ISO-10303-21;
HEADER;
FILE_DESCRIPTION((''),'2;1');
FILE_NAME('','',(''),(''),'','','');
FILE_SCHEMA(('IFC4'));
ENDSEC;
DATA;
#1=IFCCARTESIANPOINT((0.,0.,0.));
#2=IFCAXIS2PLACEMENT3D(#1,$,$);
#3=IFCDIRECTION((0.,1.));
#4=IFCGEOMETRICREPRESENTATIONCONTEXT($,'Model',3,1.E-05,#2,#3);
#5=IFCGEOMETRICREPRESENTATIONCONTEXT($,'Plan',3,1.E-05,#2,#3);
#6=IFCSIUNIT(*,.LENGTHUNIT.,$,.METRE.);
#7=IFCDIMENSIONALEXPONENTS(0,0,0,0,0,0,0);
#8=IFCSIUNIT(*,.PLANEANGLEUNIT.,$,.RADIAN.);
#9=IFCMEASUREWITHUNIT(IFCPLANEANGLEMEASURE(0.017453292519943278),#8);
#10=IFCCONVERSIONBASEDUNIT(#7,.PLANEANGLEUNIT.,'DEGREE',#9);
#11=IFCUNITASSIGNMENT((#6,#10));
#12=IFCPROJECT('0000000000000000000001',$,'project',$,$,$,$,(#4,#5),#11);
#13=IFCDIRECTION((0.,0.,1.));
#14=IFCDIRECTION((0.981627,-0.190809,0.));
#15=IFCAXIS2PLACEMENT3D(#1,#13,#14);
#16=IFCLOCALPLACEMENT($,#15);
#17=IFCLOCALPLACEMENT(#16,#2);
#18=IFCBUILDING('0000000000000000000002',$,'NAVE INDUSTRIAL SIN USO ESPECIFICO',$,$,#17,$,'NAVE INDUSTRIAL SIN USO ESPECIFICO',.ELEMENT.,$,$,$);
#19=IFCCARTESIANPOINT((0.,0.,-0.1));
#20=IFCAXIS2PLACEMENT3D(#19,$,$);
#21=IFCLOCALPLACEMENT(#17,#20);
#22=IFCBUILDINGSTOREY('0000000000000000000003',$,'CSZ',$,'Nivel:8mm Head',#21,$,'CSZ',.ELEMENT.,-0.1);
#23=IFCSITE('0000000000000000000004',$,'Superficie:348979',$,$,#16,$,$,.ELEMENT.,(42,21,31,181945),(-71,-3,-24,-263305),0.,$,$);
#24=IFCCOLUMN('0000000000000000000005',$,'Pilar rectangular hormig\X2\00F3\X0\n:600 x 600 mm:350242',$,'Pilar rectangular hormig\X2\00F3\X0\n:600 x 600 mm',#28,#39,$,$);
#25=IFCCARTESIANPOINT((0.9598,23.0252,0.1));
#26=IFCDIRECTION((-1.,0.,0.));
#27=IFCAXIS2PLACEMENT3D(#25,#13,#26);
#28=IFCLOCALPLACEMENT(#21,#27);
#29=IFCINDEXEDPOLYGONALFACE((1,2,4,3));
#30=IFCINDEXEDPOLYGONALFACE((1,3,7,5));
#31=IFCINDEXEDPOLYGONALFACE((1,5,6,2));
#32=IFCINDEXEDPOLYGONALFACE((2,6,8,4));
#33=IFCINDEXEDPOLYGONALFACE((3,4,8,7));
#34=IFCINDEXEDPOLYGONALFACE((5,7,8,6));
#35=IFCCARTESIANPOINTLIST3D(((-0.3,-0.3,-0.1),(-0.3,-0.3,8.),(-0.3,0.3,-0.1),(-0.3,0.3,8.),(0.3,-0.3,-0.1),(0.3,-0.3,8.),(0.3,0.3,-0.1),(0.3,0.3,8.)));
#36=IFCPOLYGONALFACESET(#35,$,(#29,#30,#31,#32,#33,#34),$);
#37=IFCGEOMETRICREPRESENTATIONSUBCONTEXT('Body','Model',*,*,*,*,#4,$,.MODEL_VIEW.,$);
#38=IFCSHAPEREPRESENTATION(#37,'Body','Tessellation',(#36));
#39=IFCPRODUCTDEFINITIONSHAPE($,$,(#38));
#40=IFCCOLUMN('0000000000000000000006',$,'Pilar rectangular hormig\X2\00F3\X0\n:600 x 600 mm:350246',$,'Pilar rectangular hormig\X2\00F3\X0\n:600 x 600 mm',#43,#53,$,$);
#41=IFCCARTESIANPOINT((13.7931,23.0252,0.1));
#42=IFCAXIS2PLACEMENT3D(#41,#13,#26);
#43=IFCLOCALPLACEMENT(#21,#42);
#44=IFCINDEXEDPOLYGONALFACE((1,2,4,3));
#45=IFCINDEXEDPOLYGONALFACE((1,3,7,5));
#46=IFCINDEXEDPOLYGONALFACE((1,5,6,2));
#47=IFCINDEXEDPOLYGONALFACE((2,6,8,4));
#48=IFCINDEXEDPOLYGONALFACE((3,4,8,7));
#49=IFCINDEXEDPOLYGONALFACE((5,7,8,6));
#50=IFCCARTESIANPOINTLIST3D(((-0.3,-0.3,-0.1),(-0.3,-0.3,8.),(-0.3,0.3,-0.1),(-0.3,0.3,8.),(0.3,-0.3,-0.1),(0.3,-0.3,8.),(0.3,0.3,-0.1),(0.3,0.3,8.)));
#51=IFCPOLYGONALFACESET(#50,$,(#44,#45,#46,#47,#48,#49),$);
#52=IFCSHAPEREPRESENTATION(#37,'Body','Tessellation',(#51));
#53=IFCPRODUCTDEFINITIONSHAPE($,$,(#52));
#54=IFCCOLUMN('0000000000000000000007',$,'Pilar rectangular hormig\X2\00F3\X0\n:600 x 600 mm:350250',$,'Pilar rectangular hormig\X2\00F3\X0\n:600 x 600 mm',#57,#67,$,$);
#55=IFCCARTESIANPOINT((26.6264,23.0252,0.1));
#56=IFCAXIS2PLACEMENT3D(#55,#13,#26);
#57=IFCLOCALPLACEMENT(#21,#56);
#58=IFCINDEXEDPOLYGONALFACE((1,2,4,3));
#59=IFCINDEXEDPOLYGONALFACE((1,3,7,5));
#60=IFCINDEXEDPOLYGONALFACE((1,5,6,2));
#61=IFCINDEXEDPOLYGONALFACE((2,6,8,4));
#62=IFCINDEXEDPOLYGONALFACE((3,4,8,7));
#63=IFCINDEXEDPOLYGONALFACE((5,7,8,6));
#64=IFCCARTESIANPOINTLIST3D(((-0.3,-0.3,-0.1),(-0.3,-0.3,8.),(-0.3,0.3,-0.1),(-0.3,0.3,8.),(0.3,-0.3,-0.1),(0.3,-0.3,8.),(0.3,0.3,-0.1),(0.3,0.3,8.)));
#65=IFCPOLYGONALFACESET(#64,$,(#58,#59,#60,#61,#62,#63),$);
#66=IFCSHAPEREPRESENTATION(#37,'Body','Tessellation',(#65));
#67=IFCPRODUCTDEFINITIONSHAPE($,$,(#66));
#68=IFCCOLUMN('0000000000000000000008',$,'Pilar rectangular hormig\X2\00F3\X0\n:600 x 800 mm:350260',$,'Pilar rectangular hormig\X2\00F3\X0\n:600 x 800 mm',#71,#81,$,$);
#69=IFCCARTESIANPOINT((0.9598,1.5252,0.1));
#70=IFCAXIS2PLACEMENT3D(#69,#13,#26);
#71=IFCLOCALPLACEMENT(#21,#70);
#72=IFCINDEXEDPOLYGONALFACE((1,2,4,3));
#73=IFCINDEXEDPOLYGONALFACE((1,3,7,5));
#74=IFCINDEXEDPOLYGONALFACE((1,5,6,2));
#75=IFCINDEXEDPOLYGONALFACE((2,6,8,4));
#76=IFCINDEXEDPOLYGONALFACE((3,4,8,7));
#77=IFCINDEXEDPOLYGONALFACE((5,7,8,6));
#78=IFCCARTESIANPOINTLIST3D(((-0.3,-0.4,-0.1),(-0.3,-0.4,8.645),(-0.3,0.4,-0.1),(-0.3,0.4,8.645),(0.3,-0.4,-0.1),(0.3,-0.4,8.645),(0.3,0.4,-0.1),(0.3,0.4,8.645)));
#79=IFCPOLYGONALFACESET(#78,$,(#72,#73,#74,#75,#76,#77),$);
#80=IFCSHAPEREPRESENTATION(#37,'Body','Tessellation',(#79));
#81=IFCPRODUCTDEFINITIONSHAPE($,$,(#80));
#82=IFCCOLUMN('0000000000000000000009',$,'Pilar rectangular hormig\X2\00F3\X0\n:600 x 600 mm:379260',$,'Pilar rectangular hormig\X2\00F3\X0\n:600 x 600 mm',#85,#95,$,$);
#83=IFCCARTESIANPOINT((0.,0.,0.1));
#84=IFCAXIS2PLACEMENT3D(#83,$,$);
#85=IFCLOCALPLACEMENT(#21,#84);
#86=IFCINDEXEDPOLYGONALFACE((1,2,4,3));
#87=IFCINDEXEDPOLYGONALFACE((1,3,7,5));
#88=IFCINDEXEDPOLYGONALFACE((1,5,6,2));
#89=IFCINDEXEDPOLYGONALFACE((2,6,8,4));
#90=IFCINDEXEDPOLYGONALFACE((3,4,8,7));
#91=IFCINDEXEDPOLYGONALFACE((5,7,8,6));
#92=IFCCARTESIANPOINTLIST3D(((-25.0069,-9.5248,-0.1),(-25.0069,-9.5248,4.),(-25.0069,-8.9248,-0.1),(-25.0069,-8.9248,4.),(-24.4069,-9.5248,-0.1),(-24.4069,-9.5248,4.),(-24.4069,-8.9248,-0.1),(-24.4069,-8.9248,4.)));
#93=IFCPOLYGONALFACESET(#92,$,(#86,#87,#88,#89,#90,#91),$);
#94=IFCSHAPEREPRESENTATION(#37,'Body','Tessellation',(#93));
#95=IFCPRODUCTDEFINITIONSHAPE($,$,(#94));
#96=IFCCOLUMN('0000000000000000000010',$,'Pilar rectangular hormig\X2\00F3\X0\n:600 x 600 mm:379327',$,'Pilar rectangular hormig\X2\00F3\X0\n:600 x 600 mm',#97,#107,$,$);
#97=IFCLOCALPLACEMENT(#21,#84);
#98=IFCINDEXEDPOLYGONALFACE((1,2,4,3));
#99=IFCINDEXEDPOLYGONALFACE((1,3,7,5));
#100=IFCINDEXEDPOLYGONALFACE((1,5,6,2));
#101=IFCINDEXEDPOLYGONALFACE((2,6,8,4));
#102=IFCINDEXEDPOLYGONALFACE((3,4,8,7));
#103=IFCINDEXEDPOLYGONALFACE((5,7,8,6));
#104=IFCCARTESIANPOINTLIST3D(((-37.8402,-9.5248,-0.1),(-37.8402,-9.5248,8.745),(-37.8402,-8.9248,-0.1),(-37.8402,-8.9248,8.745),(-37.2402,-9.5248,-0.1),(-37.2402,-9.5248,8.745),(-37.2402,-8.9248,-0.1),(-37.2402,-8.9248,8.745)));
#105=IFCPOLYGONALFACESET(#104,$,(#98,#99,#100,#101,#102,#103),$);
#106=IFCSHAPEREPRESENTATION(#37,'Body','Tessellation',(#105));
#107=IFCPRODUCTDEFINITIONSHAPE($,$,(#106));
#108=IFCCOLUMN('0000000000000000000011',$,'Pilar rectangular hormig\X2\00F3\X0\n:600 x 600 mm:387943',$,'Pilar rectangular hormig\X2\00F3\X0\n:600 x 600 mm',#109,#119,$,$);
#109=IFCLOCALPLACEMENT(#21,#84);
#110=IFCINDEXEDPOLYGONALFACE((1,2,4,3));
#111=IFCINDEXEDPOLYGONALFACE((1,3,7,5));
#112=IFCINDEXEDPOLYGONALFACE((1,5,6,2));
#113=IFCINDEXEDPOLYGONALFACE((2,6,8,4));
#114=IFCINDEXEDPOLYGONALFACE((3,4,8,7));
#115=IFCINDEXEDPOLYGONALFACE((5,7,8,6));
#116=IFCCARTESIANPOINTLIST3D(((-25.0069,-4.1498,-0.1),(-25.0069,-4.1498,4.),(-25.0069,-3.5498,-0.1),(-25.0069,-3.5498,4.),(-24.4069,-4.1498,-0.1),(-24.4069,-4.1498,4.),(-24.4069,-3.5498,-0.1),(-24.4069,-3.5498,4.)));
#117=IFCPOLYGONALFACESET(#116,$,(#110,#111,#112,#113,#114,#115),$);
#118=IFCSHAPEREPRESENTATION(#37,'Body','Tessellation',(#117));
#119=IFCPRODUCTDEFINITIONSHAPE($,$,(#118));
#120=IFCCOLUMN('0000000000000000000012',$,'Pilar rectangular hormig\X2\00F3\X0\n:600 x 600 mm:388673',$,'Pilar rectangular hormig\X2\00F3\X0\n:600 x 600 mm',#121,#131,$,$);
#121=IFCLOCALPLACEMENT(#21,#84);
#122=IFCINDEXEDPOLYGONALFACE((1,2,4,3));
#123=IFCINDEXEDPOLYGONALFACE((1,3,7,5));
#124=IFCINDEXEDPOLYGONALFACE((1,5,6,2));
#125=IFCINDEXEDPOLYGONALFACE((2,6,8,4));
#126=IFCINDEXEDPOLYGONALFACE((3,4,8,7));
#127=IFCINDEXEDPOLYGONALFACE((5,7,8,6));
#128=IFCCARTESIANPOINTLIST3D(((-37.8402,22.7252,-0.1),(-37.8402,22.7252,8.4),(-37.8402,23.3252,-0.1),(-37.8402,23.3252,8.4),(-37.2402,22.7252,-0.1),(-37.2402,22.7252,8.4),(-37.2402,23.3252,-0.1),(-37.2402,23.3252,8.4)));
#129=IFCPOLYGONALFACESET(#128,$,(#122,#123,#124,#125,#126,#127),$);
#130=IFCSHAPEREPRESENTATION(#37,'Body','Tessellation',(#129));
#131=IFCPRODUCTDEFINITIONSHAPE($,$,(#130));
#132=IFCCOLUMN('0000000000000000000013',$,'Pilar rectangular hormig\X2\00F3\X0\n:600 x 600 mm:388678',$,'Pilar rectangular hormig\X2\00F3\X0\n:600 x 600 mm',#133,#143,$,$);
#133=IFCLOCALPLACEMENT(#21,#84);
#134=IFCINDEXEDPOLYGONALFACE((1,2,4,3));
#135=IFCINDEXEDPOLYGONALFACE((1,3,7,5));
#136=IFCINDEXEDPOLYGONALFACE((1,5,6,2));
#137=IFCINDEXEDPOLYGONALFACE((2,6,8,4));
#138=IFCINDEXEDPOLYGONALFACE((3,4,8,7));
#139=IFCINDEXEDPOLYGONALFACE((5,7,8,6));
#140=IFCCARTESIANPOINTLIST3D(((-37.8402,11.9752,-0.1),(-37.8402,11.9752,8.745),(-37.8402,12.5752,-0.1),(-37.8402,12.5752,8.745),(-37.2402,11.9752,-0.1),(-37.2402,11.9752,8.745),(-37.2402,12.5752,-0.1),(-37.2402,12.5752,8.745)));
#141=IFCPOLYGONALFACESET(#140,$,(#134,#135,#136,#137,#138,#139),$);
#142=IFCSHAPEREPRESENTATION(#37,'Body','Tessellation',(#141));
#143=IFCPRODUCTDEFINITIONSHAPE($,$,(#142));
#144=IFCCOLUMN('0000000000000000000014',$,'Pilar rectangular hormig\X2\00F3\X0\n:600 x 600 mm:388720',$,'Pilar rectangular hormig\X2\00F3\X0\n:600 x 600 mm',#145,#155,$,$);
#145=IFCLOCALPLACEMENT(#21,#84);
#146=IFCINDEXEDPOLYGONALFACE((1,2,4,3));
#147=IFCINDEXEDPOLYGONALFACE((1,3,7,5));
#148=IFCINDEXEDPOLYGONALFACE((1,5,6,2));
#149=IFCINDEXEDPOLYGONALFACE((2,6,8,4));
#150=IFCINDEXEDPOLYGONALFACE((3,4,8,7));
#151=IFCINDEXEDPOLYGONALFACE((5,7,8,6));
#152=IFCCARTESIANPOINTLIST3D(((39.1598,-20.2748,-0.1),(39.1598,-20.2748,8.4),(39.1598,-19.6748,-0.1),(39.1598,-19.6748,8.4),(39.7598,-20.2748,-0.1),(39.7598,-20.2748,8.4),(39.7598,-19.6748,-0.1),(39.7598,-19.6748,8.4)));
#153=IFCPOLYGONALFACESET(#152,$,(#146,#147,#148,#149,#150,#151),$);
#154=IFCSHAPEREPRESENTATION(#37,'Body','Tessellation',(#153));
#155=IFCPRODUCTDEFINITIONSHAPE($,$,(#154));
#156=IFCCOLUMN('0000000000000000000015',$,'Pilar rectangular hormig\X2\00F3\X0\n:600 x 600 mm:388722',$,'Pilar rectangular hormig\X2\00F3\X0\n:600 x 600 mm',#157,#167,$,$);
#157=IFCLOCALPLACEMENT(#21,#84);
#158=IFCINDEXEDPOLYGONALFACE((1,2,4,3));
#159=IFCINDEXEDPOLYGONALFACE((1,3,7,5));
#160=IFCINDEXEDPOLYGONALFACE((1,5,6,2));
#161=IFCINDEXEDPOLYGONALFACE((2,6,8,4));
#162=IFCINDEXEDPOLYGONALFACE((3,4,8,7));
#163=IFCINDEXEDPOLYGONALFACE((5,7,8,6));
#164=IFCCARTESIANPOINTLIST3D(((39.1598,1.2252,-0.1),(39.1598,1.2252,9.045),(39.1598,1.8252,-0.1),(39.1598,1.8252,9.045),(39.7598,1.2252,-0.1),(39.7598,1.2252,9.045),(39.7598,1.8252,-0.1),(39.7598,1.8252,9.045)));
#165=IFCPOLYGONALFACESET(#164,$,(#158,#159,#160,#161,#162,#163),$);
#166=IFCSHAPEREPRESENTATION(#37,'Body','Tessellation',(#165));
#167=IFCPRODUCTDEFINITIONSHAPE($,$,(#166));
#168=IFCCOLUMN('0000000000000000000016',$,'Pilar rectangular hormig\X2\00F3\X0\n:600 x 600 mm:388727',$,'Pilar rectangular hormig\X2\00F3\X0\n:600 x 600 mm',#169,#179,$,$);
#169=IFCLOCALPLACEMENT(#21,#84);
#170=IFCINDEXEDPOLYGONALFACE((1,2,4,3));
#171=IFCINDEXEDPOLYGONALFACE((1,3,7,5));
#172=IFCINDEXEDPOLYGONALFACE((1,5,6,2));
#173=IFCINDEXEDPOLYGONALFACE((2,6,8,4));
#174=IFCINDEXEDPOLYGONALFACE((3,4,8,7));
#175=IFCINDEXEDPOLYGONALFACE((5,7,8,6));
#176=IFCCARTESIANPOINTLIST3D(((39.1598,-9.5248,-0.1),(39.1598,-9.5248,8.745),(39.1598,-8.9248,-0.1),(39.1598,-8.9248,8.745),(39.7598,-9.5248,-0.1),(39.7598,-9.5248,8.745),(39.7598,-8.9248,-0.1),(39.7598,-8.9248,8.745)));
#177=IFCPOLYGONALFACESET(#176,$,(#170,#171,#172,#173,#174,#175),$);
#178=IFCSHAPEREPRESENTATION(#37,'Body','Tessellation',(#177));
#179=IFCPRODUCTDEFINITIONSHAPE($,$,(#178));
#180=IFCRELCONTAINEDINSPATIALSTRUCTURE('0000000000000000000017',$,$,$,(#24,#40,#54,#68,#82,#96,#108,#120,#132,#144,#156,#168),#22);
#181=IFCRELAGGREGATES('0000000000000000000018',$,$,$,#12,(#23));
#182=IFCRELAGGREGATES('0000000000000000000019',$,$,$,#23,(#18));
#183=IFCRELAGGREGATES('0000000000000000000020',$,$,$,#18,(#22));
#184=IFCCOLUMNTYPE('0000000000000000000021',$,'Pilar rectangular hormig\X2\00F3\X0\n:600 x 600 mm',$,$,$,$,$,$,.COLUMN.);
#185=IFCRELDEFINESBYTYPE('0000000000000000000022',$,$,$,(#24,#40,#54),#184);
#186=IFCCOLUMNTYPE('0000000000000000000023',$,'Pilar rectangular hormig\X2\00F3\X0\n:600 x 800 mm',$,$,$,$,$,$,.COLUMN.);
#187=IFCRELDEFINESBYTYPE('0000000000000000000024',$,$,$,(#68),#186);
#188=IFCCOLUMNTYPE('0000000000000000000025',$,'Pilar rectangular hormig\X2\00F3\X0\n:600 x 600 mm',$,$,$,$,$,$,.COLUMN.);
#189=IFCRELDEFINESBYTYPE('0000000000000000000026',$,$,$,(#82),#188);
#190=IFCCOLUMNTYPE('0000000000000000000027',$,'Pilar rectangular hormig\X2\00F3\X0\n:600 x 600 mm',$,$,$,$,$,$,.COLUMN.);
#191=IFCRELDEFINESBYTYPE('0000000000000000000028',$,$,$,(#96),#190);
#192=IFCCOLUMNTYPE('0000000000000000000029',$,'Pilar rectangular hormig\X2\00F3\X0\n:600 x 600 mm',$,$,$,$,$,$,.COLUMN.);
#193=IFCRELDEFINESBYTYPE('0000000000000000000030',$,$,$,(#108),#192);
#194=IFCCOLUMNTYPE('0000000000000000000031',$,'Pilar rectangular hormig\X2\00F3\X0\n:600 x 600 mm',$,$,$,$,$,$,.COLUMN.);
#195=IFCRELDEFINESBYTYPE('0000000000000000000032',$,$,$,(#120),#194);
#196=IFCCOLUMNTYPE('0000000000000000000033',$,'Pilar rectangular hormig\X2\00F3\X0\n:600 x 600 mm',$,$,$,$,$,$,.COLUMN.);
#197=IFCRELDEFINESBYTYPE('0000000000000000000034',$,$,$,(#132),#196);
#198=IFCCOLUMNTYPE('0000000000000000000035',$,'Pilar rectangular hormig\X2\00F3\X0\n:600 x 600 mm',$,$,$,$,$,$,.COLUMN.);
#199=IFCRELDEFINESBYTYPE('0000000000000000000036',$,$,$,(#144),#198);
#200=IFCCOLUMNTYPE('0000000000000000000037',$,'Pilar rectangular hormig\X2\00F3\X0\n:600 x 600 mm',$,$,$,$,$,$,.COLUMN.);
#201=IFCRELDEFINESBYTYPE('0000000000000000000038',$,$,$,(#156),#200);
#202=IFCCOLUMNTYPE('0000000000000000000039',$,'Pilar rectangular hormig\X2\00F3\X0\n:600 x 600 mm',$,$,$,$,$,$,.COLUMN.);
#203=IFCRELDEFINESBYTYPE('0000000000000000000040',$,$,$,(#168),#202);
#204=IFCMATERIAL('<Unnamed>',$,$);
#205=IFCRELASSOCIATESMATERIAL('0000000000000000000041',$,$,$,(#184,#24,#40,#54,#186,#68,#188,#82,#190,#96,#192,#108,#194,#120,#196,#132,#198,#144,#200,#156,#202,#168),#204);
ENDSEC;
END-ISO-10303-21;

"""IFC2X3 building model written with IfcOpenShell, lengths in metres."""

from ifc_helpers import new_model, entity, si_unit, converted_unit, direction, frame, frame_2d, origin, origin_2d_with_axis, place, context, subcontext, project, spatial, rectangle, extrude, source, transform, mapped, material, type_object, type_shapes, element, save


model = new_model("IFC2X3")

# Units and contexts
model_context = context("Model", 3, precision=1e-05, world=origin(), true_north=direction((0.0, 1.0)))
plan_context = context("Plan", 3, precision=1e-05, world=origin(), true_north=direction((0.0, 1.0)))
body_context = subcontext(model_context, "Body", "Model", "MODEL_VIEW")
ifc_project = project(units=[si_unit("LENGTHUNIT", "METRE"), converted_unit("PLANEANGLEUNIT", "DEGREE", entity("IfcPlaneAngleMeasure", 0.017453292519943278), si_unit("PLANEANGLEUNIT", "RADIAN"), dimensions=[0, 0, 0, 0, 0, 0, 0])], contexts=[model_context, plan_context])

# Site, building, storey
site_placement = place(None, frame((0.0, 0.0, 0.0), z_axis=(0.0, 0.0, 1.0), x_axis=(0.981627, -0.190809, 0.0)))
site = spatial("IfcSite", under=ifc_project, at=site_placement, Name="Superficie:348979", CompositionType="ELEMENT", RefLatitude=(42, 21, 31, 181945), RefLongitude=(-71, -3, -24, -263305), RefElevation=0.0)
building_placement = place(site_placement, origin())
building = spatial("IfcBuilding", under=site, at=building_placement, Name="NAVE INDUSTRIAL SIN USO ESPECIFICO", LongName="NAVE INDUSTRIAL SIN USO ESPECIFICO", CompositionType="ELEMENT")
storey_placement = place(building_placement, frame((0.0, 0.0, -0.1)))
storey = spatial("IfcBuildingStorey", under=building, at=storey_placement, Name="CSZ", ObjectType="Nivel:8mm Head", LongName="CSZ", CompositionType="ELEMENT", Elevation=-0.1)

# Columns
ifc_material_1 = material(Name="<Unnamed>")
column_type_1 = type_object("IfcColumnType", Name="Pilar rectangular hormigón:600 x 600 mm", PredefinedType="COLUMN", material=ifc_material_1)
shared_shape_1 = source(origin(), body_context, "Body", "SweptSolid", [
    extrude(rectangle(XDim=0.6, YDim=0.6, at=origin_2d_with_axis()), frame((0.0, 0.0, -0.1), z_axis=(0.0, 0.0, 1.0), x_axis=(-1.0, 0.0, 0.0)), (0.0, 0.0, 1.0), 8.1),
])
type_shapes(column_type_1, [shared_shape_1])
for number, where, z_axis, x_axis, name in (
    (1, (0.9598, 23.0252, 0.1), (0.0, 0.0, 1.0), (-1.0, 0.0, 0.0), "Pilar rectangular hormigón:600 x 600 mm:350242"),
    (2, (13.7931, 23.0252, 0.1), (0.0, 0.0, 1.0), (-1.0, 0.0, 0.0), "Pilar rectangular hormigón:600 x 600 mm:350246"),
    (3, (26.6264, 23.0252, 0.1), (0.0, 0.0, 1.0), (-1.0, 0.0, 0.0), "Pilar rectangular hormigón:600 x 600 mm:350250"),
):
    element("IfcColumn", number, at=place(storey_placement, frame(where, z_axis=z_axis, x_axis=x_axis)), inside=storey, type_object=column_type_1, material=ifc_material_1, Name=name, ObjectType="Pilar rectangular hormigón:600 x 600 mm", context=body_context, shape_type="MappedRepresentation", body=[
        mapped(shared_shape_1, transform((0.0, 0.0, 0.0), scale=1.0)),
    ])
column_type_2 = type_object("IfcColumnType", Name="Pilar rectangular hormigón:600 x 800 mm", PredefinedType="COLUMN", material=ifc_material_1)
shared_shape_2 = source(origin(), body_context, "Body", "SweptSolid", [
    extrude(rectangle(XDim=0.6, YDim=0.8, at=origin_2d_with_axis()), frame((0.0, 0.0, -0.1), z_axis=(0.0, 0.0, 1.0), x_axis=(-1.0, 0.0, 0.0)), (0.0, 0.0, 1.0), 8.745),
])
type_shapes(column_type_2, [shared_shape_2])
column_1_placement = place(storey_placement, frame((0.9598, 1.5252, 0.1), z_axis=(0.0, 0.0, 1.0), x_axis=(-1.0, 0.0, 0.0)))
element("IfcColumn", 4, at=column_1_placement, inside=storey, type_object=column_type_2, material=ifc_material_1, Name="Pilar rectangular hormigón:600 x 800 mm:350260", ObjectType="Pilar rectangular hormigón:600 x 800 mm", context=body_context, shape_type="MappedRepresentation", body=[
    mapped(shared_shape_2, transform((0.0, 0.0, 0.0), scale=1.0)),
])
column_type_3 = type_object("IfcColumnType", Name="Pilar rectangular hormigón:600 x 600 mm", PredefinedType="COLUMN", material=ifc_material_1)
shared_shape_3 = source(origin(), body_context, "Body", "SweptSolid", [
    extrude(rectangle(XDim=0.6, YDim=0.6, at=frame_2d((0.0, 0.0), x_axis=(1.0, 0.0))), frame((-24.7069, -9.2248, -0.1)), (0.0, 0.0, 1.0), 4.1),
])
type_shapes(column_type_3, [shared_shape_3])
column_2_placement = place(storey_placement, frame((0.0, 0.0, 0.1)))
element("IfcColumn", 5, at=column_2_placement, inside=storey, type_object=column_type_3, material=ifc_material_1, Name="Pilar rectangular hormigón:600 x 600 mm:379260", ObjectType="Pilar rectangular hormigón:600 x 600 mm", context=body_context, shape_type="MappedRepresentation", body=[
    mapped(shared_shape_3, transform((0.0, 0.0, 0.0), scale=1.0)),
])
column_type_4 = type_object("IfcColumnType", Name="Pilar rectangular hormigón:600 x 600 mm", PredefinedType="COLUMN", material=ifc_material_1)
shared_shape_4 = source(origin(), body_context, "Body", "SweptSolid", [
    extrude(rectangle(XDim=0.6, YDim=0.6, at=frame_2d((0.0, 0.0), x_axis=(1.0, 0.0))), frame((-37.5402, -9.2248, -0.1)), (0.0, 0.0, 1.0), 8.845),
])
type_shapes(column_type_4, [shared_shape_4])
column_3_placement = place(storey_placement, frame((0.0, 0.0, 0.1)))
element("IfcColumn", 6, at=column_3_placement, inside=storey, type_object=column_type_4, material=ifc_material_1, Name="Pilar rectangular hormigón:600 x 600 mm:379327", ObjectType="Pilar rectangular hormigón:600 x 600 mm", context=body_context, shape_type="MappedRepresentation", body=[
    mapped(shared_shape_4, transform((0.0, 0.0, 0.0), scale=1.0)),
])
column_type_5 = type_object("IfcColumnType", Name="Pilar rectangular hormigón:600 x 600 mm", PredefinedType="COLUMN", material=ifc_material_1)
shared_shape_5 = source(origin(), body_context, "Body", "SweptSolid", [
    extrude(rectangle(XDim=0.6, YDim=0.6, at=frame_2d((0.0, 0.0), x_axis=(1.0, 0.0))), frame((-24.7069, -3.8498, -0.1)), (0.0, 0.0, 1.0), 4.1),
])
type_shapes(column_type_5, [shared_shape_5])
column_4_placement = place(storey_placement, frame((0.0, 0.0, 0.1)))
element("IfcColumn", 7, at=column_4_placement, inside=storey, type_object=column_type_5, material=ifc_material_1, Name="Pilar rectangular hormigón:600 x 600 mm:387943", ObjectType="Pilar rectangular hormigón:600 x 600 mm", context=body_context, shape_type="MappedRepresentation", body=[
    mapped(shared_shape_5, transform((0.0, 0.0, 0.0), scale=1.0)),
])
column_type_6 = type_object("IfcColumnType", Name="Pilar rectangular hormigón:600 x 600 mm", PredefinedType="COLUMN", material=ifc_material_1)
shared_shape_6 = source(origin(), body_context, "Body", "SweptSolid", [
    extrude(rectangle(XDim=0.6, YDim=0.6, at=frame_2d((0.0, 0.0), x_axis=(1.0, 0.0))), frame((-37.5402, 23.0252, -0.1), z_axis=(0.0, 0.0, 1.0), x_axis=(0.0, -1.0, 0.0)), (0.0, 0.0, 1.0), 8.5),
])
type_shapes(column_type_6, [shared_shape_6])
column_5_placement = place(storey_placement, frame((0.0, 0.0, 0.1)))
element("IfcColumn", 8, at=column_5_placement, inside=storey, type_object=column_type_6, material=ifc_material_1, Name="Pilar rectangular hormigón:600 x 600 mm:388673", ObjectType="Pilar rectangular hormigón:600 x 600 mm", context=body_context, shape_type="MappedRepresentation", body=[
    mapped(shared_shape_6, transform((0.0, 0.0, 0.0), scale=1.0)),
])
column_type_7 = type_object("IfcColumnType", Name="Pilar rectangular hormigón:600 x 600 mm", PredefinedType="COLUMN", material=ifc_material_1)
shared_shape_7 = source(origin(), body_context, "Body", "SweptSolid", [
    extrude(rectangle(XDim=0.6, YDim=0.6, at=frame_2d((0.0, 0.0), x_axis=(1.0, 0.0))), frame((-37.5402, 12.2752, -0.1), z_axis=(0.0, 0.0, 1.0), x_axis=(0.0, -1.0, 0.0)), (0.0, 0.0, 1.0), 8.845),
])
type_shapes(column_type_7, [shared_shape_7])
column_6_placement = place(storey_placement, frame((0.0, 0.0, 0.1)))
element("IfcColumn", 9, at=column_6_placement, inside=storey, type_object=column_type_7, material=ifc_material_1, Name="Pilar rectangular hormigón:600 x 600 mm:388678", ObjectType="Pilar rectangular hormigón:600 x 600 mm", context=body_context, shape_type="MappedRepresentation", body=[
    mapped(shared_shape_7, transform((0.0, 0.0, 0.0), scale=1.0)),
])
column_type_8 = type_object("IfcColumnType", Name="Pilar rectangular hormigón:600 x 600 mm", PredefinedType="COLUMN", material=ifc_material_1)
shared_shape_8 = source(origin(), body_context, "Body", "SweptSolid", [
    extrude(rectangle(XDim=0.6, YDim=0.6, at=frame_2d((0.0, 0.0), x_axis=(1.0, 0.0))), frame((39.4598, -19.9748, -0.1), z_axis=(0.0, 0.0, 1.0), x_axis=(0.0, 1.0, 0.0)), (0.0, 0.0, 1.0), 8.5),
])
type_shapes(column_type_8, [shared_shape_8])
column_7_placement = place(storey_placement, frame((0.0, 0.0, 0.1)))
element("IfcColumn", 10, at=column_7_placement, inside=storey, type_object=column_type_8, material=ifc_material_1, Name="Pilar rectangular hormigón:600 x 600 mm:388720", ObjectType="Pilar rectangular hormigón:600 x 600 mm", context=body_context, shape_type="MappedRepresentation", body=[
    mapped(shared_shape_8, transform((0.0, 0.0, 0.0), scale=1.0)),
])
column_type_9 = type_object("IfcColumnType", Name="Pilar rectangular hormigón:600 x 600 mm", PredefinedType="COLUMN", material=ifc_material_1)
shared_shape_9 = source(origin(), body_context, "Body", "SweptSolid", [
    extrude(rectangle(XDim=0.6, YDim=0.6, at=origin_2d_with_axis()), frame((39.4598, 1.5252, -0.1), z_axis=(0.0, 0.0, 1.0), x_axis=(0.0, 1.0, 0.0)), (0.0, 0.0, 1.0), 9.145),
])
type_shapes(column_type_9, [shared_shape_9])
column_8_placement = place(storey_placement, frame((0.0, 0.0, 0.1)))
element("IfcColumn", 11, at=column_8_placement, inside=storey, type_object=column_type_9, material=ifc_material_1, Name="Pilar rectangular hormigón:600 x 600 mm:388722", ObjectType="Pilar rectangular hormigón:600 x 600 mm", context=body_context, shape_type="MappedRepresentation", body=[
    mapped(shared_shape_9, transform((0.0, 0.0, 0.0), scale=1.0)),
])
column_type_10 = type_object("IfcColumnType", Name="Pilar rectangular hormigón:600 x 600 mm", PredefinedType="COLUMN", material=ifc_material_1)
shared_shape_10 = source(origin(), body_context, "Body", "SweptSolid", [
    extrude(rectangle(XDim=0.6, YDim=0.6, at=origin_2d_with_axis()), frame((39.4598, -9.2248, -0.1), z_axis=(0.0, 0.0, 1.0), x_axis=(0.0, 1.0, 0.0)), (0.0, 0.0, 1.0), 8.845),
])
type_shapes(column_type_10, [shared_shape_10])
column_9_placement = place(storey_placement, frame((0.0, 0.0, 0.1)))
element("IfcColumn", 12, at=column_9_placement, inside=storey, type_object=column_type_10, material=ifc_material_1, Name="Pilar rectangular hormigón:600 x 600 mm:388727", ObjectType="Pilar rectangular hormigón:600 x 600 mm", context=body_context, shape_type="MappedRepresentation", body=[
    mapped(shared_shape_10, transform((0.0, 0.0, 0.0), scale=1.0)),
])

save(model, "model.ifc")
